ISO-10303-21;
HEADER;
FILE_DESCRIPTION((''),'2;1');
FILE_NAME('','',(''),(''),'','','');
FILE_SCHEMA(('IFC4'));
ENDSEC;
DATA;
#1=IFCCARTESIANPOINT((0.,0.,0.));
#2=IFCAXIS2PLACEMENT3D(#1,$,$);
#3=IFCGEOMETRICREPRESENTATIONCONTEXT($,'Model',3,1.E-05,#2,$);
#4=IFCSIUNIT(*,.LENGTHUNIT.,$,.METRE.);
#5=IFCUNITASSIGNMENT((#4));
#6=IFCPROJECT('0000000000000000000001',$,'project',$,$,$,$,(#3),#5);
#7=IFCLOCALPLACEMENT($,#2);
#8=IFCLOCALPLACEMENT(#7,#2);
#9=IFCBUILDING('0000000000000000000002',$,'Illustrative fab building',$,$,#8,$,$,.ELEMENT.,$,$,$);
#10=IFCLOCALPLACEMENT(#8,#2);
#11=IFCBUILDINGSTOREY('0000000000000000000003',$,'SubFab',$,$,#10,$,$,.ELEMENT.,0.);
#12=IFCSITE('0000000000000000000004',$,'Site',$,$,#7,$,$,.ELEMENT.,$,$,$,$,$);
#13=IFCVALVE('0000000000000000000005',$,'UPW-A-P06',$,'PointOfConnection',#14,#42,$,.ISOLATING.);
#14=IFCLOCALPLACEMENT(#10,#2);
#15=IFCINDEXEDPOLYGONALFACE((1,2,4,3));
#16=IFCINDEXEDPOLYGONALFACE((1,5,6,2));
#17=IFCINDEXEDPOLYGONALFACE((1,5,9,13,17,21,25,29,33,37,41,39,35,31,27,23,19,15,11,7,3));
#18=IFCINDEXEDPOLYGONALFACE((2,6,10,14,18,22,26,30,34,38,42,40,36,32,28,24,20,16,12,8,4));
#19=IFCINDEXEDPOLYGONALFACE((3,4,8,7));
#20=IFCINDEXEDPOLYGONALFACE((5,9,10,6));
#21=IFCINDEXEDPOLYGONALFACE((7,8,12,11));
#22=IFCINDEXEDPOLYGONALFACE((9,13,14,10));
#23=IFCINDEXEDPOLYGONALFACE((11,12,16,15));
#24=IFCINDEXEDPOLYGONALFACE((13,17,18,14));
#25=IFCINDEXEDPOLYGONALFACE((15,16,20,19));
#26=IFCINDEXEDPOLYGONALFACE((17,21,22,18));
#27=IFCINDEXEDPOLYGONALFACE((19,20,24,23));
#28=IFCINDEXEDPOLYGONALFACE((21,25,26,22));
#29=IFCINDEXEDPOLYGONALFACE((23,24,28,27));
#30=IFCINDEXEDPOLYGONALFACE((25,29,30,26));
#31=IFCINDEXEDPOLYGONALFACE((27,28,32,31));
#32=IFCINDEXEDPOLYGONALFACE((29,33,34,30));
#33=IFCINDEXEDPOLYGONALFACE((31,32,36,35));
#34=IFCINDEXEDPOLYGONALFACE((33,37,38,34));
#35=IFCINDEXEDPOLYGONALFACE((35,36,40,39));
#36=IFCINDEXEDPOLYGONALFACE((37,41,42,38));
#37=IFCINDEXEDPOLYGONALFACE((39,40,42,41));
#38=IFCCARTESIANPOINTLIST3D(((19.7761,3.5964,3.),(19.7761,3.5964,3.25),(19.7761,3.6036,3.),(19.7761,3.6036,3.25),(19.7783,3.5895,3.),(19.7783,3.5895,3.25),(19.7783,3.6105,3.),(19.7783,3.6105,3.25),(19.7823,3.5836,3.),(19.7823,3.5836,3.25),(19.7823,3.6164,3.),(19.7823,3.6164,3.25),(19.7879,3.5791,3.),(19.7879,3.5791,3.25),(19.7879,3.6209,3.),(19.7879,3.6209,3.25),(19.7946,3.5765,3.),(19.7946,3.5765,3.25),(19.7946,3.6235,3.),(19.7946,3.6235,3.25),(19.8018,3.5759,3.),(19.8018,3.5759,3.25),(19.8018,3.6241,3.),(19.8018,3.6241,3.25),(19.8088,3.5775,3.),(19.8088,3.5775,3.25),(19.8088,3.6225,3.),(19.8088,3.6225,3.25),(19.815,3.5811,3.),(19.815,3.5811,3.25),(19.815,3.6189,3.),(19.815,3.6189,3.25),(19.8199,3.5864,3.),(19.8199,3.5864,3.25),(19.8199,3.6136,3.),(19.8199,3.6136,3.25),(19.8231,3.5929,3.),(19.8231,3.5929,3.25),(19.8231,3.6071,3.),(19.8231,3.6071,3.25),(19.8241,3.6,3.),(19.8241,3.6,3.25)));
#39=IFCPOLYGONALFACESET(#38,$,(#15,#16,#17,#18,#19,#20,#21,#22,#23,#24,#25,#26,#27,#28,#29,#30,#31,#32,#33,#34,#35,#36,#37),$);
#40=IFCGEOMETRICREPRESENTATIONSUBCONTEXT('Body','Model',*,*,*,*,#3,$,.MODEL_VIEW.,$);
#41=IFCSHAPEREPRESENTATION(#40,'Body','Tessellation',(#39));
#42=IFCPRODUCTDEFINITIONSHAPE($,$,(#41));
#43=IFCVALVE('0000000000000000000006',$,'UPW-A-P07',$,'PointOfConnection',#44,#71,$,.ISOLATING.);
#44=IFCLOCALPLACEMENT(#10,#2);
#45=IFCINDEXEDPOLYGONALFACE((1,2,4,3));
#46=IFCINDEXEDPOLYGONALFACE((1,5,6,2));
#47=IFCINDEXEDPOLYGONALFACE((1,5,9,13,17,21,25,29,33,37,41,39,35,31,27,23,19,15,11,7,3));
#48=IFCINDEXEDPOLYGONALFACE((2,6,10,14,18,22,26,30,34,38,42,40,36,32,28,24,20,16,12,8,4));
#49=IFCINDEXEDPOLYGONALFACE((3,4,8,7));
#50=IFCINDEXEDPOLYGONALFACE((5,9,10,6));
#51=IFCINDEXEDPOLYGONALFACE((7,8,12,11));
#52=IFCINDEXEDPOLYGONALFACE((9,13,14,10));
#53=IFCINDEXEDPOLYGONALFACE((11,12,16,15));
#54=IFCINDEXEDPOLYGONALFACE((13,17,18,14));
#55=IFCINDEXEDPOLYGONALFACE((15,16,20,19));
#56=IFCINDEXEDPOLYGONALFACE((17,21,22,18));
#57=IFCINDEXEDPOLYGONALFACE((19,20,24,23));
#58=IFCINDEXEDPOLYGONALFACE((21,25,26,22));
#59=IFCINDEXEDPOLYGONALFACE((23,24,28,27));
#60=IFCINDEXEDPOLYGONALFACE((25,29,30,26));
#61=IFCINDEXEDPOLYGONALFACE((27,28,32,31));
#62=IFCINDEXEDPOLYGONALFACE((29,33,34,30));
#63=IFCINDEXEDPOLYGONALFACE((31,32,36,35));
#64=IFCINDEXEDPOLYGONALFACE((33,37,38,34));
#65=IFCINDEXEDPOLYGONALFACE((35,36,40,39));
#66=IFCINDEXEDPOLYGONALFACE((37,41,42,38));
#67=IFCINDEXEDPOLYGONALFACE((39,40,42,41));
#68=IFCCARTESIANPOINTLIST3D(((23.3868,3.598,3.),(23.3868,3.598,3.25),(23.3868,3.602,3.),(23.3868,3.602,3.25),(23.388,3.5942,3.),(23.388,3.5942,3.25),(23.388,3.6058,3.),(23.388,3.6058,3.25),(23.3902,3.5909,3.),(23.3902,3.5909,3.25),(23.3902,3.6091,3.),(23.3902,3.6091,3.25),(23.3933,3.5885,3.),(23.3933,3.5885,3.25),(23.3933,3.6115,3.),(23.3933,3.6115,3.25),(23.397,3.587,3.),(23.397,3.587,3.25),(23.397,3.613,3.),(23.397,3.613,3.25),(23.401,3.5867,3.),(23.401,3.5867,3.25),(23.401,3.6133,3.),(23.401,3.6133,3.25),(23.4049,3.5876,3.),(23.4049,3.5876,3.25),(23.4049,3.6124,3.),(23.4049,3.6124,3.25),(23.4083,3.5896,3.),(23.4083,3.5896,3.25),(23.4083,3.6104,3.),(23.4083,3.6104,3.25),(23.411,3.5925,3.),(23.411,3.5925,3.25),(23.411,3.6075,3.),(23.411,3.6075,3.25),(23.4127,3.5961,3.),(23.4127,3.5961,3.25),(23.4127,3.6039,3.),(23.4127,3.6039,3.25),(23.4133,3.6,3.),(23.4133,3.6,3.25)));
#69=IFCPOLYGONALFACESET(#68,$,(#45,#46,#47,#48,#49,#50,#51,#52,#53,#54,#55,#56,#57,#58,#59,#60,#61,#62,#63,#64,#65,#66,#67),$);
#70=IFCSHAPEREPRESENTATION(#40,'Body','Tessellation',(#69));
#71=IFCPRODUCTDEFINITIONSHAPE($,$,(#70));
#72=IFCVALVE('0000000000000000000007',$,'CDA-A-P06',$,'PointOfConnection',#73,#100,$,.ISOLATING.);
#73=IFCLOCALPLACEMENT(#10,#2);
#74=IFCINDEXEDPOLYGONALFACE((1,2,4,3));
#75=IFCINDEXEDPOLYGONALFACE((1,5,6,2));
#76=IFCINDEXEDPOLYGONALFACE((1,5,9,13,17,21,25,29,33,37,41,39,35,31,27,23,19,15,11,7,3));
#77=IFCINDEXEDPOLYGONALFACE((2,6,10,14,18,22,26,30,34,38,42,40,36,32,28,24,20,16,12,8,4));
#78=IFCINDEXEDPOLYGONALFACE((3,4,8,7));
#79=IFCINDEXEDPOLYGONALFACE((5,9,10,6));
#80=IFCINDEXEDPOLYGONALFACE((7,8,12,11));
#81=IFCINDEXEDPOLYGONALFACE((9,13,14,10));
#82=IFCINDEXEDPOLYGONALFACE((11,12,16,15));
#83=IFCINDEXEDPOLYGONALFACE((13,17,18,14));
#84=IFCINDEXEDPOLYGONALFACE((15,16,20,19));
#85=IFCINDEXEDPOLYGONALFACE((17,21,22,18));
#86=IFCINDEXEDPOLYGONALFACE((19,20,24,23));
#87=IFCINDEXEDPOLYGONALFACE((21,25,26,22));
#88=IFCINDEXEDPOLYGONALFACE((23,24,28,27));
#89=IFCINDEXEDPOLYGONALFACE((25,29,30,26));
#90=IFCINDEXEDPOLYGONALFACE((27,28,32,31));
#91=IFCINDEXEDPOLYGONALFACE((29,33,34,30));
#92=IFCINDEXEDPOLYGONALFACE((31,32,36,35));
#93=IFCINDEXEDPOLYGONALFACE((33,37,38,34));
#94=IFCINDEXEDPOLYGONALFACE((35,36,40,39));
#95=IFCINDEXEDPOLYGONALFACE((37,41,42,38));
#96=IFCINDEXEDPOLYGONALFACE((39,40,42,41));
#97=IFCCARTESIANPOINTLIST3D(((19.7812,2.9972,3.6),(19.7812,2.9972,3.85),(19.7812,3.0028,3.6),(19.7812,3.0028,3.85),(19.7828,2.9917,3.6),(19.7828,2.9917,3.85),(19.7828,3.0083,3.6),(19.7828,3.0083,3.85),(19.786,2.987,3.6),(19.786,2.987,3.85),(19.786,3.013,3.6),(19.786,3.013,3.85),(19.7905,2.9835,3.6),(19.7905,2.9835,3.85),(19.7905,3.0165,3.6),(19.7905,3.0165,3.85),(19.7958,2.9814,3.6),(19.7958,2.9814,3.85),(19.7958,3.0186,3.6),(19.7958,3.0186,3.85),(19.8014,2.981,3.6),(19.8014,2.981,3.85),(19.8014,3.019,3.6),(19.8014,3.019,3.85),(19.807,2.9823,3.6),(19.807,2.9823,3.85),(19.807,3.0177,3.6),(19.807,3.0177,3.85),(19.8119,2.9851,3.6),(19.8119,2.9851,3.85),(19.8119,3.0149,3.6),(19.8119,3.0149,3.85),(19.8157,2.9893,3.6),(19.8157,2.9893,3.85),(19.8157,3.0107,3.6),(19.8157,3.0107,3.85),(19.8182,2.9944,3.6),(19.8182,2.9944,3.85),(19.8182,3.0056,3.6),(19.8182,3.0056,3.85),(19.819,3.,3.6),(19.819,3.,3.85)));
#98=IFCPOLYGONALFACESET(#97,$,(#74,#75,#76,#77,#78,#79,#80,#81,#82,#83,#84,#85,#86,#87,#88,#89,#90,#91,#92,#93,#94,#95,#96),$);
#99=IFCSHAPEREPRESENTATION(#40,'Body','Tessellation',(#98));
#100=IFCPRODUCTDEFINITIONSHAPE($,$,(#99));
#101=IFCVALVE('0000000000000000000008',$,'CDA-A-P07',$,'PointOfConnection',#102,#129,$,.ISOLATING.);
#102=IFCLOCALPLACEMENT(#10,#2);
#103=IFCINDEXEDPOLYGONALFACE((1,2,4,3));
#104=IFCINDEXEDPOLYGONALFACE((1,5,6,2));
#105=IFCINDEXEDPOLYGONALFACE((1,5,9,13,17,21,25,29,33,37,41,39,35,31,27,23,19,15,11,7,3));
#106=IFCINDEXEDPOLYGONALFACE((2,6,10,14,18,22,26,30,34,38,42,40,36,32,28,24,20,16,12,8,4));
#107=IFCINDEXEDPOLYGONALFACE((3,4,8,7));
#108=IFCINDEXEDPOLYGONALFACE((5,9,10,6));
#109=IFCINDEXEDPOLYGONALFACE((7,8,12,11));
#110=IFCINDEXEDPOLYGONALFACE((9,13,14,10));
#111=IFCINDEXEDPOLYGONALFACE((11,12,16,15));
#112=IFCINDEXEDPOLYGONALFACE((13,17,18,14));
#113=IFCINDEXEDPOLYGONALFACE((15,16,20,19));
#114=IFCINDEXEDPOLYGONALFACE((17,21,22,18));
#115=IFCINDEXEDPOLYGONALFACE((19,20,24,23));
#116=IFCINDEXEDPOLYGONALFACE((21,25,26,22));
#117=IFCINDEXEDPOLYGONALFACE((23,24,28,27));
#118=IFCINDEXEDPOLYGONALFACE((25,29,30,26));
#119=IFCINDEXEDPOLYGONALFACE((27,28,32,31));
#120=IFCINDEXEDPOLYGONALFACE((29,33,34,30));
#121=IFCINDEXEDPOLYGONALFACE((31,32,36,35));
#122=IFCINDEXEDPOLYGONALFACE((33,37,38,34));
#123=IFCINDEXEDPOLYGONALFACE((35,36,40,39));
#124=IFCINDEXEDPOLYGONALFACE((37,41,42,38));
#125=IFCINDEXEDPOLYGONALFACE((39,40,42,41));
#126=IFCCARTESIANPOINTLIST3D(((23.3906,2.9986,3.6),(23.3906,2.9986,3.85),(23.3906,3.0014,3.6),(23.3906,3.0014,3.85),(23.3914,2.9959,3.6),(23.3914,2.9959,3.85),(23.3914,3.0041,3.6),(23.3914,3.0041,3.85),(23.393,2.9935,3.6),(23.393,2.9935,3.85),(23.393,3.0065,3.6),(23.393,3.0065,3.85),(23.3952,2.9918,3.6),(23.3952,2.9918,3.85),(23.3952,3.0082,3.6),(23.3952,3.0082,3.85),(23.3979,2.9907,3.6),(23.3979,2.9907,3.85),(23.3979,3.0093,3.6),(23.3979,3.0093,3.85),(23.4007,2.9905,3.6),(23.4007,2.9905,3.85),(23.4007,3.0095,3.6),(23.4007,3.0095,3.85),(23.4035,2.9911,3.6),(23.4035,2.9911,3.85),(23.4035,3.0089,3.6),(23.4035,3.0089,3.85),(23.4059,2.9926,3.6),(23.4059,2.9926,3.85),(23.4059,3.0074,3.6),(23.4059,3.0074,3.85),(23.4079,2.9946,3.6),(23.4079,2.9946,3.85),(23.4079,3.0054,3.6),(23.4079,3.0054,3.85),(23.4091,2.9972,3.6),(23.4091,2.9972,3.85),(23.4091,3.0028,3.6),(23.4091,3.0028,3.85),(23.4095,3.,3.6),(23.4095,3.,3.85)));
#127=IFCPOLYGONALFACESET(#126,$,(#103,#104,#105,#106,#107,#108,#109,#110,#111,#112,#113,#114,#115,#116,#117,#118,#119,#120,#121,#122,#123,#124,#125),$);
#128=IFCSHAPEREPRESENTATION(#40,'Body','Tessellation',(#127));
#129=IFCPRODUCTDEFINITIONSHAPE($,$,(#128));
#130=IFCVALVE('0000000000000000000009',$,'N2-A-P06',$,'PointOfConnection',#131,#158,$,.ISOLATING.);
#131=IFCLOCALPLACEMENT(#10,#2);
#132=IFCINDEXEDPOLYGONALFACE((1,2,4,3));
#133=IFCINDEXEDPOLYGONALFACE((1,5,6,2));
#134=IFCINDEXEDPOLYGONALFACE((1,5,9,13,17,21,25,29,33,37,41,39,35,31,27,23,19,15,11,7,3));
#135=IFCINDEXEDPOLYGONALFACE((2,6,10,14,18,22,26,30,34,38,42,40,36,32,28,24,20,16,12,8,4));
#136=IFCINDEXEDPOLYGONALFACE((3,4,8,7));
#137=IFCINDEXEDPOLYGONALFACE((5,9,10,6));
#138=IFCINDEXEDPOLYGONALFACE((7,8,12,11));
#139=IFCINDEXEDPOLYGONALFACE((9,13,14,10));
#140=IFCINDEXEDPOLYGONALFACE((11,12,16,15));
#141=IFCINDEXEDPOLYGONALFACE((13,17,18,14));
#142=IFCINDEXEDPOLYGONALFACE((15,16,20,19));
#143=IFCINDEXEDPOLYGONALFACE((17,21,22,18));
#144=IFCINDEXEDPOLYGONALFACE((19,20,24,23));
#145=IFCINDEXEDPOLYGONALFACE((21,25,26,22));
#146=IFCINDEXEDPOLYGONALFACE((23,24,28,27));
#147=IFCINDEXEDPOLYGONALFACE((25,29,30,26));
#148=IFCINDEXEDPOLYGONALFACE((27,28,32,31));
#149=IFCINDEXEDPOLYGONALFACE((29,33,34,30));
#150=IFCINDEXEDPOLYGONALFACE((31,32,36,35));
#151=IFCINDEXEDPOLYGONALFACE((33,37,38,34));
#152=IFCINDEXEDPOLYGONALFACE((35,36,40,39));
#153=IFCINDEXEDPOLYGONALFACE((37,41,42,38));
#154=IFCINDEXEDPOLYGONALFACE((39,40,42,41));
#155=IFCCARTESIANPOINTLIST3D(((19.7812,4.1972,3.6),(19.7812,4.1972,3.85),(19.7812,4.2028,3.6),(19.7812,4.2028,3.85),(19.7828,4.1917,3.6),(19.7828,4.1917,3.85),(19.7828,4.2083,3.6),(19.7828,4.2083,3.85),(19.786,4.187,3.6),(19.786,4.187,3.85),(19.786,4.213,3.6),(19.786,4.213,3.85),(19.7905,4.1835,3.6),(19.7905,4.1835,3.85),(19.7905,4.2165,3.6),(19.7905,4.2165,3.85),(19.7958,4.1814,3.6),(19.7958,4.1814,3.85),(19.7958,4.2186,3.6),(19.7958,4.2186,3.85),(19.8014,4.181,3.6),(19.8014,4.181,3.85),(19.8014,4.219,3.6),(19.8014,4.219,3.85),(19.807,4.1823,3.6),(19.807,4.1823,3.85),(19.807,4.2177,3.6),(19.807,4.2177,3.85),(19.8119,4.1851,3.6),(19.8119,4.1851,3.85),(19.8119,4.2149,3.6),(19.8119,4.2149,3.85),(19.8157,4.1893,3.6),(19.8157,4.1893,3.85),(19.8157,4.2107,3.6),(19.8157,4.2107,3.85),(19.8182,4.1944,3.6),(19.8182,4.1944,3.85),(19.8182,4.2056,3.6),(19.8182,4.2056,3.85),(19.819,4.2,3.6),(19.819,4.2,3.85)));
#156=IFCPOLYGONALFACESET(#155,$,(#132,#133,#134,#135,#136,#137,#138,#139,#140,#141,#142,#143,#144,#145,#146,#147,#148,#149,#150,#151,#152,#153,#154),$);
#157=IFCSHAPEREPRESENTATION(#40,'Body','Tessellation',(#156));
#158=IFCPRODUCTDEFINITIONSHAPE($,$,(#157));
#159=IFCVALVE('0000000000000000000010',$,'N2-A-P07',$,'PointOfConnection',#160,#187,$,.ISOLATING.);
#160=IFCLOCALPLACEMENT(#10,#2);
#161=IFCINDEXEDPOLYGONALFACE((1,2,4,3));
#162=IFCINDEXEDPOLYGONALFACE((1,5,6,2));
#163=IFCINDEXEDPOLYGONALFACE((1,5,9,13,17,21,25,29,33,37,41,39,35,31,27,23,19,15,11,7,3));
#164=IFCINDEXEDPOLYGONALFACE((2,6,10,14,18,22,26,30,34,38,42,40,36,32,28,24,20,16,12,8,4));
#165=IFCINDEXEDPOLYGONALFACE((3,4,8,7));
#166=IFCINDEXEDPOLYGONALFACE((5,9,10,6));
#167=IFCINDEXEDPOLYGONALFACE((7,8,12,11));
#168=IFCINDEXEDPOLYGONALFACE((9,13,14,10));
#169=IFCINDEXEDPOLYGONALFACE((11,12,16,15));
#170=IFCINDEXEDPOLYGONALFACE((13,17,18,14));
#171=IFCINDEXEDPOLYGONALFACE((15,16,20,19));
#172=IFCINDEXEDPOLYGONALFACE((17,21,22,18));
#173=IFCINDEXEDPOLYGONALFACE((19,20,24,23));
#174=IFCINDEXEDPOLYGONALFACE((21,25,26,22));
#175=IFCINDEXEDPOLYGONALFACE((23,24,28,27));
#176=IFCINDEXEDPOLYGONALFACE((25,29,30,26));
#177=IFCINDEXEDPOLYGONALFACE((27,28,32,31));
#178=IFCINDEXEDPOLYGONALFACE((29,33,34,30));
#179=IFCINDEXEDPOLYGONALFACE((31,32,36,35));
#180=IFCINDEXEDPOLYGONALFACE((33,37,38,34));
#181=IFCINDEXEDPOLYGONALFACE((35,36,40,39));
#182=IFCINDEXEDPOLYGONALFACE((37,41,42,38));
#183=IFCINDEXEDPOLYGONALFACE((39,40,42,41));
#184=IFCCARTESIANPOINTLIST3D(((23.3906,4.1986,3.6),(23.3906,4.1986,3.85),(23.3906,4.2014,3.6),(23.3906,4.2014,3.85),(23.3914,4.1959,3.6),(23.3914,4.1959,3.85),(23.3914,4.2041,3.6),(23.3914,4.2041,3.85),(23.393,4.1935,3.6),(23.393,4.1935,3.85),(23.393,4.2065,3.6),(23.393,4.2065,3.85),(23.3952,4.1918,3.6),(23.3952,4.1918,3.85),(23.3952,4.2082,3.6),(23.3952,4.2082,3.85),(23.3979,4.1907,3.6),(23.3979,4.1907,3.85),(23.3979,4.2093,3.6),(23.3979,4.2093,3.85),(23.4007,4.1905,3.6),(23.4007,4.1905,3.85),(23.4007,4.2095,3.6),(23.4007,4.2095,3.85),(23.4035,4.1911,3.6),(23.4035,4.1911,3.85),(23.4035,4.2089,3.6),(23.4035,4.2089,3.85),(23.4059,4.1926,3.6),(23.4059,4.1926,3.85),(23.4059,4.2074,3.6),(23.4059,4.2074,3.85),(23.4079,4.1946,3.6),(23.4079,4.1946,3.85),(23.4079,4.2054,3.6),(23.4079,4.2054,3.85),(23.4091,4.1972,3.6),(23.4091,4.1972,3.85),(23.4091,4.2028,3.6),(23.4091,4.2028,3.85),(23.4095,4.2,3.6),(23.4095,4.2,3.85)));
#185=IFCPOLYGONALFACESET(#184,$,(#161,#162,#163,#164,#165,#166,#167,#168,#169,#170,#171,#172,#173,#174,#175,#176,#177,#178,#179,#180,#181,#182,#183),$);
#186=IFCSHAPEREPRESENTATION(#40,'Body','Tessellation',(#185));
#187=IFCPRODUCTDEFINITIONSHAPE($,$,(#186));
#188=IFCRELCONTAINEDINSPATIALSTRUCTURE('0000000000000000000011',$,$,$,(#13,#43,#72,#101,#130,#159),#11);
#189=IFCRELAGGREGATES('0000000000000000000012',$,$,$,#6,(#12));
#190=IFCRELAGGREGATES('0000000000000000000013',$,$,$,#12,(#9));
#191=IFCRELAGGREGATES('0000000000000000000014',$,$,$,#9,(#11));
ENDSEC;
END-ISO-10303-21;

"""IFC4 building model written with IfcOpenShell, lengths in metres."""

from ifc_helpers import new_model, entity, si_unit, frame, origin, place, context, subcontext, project, spatial, element, save


model = new_model("IFC4")

# Units and contexts
model_context = context("Model", 3, precision=1e-05, world=origin())
body_context = subcontext(model_context, "Body", "Model", "MODEL_VIEW")
ifc_project = project(units=[si_unit("LENGTHUNIT", "METRE")], contexts=[model_context])

# Site, building, storey
site_placement = place(None, origin())
site = spatial("IfcSite", under=ifc_project, at=site_placement, Name="Site", CompositionType="ELEMENT")
building_placement = place(site_placement, origin())
building = spatial("IfcBuilding", under=site, at=building_placement, Name="Illustrative fab building", CompositionType="ELEMENT")
storey_placement = place(building_placement, origin())
storey = spatial("IfcBuildingStorey", under=building, at=storey_placement, Name="SubFab", CompositionType="ELEMENT", Elevation=0.0)

# Valves
valve_1_placement = place(storey_placement, frame((19.8, 3.6, 3.0)))
element("IfcValve", 1, at=valve_1_placement, inside=storey, Name="UPW-A-P06", ObjectType="PointOfConnection", PredefinedType="ISOLATING", context=body_context, shape_type="AdvancedSweptSolid", body=[
    entity("IfcSweptDiskSolid", entity("IfcPolyline", [entity("IfcCartesianPoint", [0.0, 0.0, 0.0]), entity("IfcCartesianPoint", [0.0, 0.0, 0.25])]), 0.0241),
])
valve_2_placement = place(storey_placement, frame((23.4, 3.6, 3.0)))
element("IfcValve", 2, at=valve_2_placement, inside=storey, Name="UPW-A-P07", ObjectType="PointOfConnection", PredefinedType="ISOLATING", context=body_context, shape_type="AdvancedSweptSolid", body=[
    entity("IfcSweptDiskSolid", entity("IfcPolyline", [entity("IfcCartesianPoint", [0.0, 0.0, 0.0]), entity("IfcCartesianPoint", [0.0, 0.0, 0.25])]), 0.0133),
])
valve_3_placement = place(storey_placement, frame((19.8, 3.0, 3.6)))
element("IfcValve", 3, at=valve_3_placement, inside=storey, Name="CDA-A-P06", ObjectType="PointOfConnection", PredefinedType="ISOLATING", context=body_context, shape_type="AdvancedSweptSolid", body=[
    entity("IfcSweptDiskSolid", entity("IfcPolyline", [entity("IfcCartesianPoint", [0.0, 0.0, 0.0]), entity("IfcCartesianPoint", [0.0, 0.0, 0.25])]), 0.019),
])
valve_4_placement = place(storey_placement, frame((23.4, 3.0, 3.6)))
element("IfcValve", 4, at=valve_4_placement, inside=storey, Name="CDA-A-P07", ObjectType="PointOfConnection", PredefinedType="ISOLATING", context=body_context, shape_type="AdvancedSweptSolid", body=[
    entity("IfcSweptDiskSolid", entity("IfcPolyline", [entity("IfcCartesianPoint", [0.0, 0.0, 0.0]), entity("IfcCartesianPoint", [0.0, 0.0, 0.25])]), 0.0095),
])
valve_5_placement = place(storey_placement, frame((19.8, 4.2, 3.6)))
element("IfcValve", 5, at=valve_5_placement, inside=storey, Name="N2-A-P06", ObjectType="PointOfConnection", PredefinedType="ISOLATING", context=body_context, shape_type="AdvancedSweptSolid", body=[
    entity("IfcSweptDiskSolid", entity("IfcPolyline", [entity("IfcCartesianPoint", [0.0, 0.0, 0.0]), entity("IfcCartesianPoint", [0.0, 0.0, 0.25])]), 0.019),
])
valve_6_placement = place(storey_placement, frame((23.4, 4.2, 3.6)))
element("IfcValve", 6, at=valve_6_placement, inside=storey, Name="N2-A-P07", ObjectType="PointOfConnection", PredefinedType="ISOLATING", context=body_context, shape_type="AdvancedSweptSolid", body=[
    entity("IfcSweptDiskSolid", entity("IfcPolyline", [entity("IfcCartesianPoint", [0.0, 0.0, 0.0]), entity("IfcCartesianPoint", [0.0, 0.0, 0.25])]), 0.0095),
])

save(model, "model.ifc")
